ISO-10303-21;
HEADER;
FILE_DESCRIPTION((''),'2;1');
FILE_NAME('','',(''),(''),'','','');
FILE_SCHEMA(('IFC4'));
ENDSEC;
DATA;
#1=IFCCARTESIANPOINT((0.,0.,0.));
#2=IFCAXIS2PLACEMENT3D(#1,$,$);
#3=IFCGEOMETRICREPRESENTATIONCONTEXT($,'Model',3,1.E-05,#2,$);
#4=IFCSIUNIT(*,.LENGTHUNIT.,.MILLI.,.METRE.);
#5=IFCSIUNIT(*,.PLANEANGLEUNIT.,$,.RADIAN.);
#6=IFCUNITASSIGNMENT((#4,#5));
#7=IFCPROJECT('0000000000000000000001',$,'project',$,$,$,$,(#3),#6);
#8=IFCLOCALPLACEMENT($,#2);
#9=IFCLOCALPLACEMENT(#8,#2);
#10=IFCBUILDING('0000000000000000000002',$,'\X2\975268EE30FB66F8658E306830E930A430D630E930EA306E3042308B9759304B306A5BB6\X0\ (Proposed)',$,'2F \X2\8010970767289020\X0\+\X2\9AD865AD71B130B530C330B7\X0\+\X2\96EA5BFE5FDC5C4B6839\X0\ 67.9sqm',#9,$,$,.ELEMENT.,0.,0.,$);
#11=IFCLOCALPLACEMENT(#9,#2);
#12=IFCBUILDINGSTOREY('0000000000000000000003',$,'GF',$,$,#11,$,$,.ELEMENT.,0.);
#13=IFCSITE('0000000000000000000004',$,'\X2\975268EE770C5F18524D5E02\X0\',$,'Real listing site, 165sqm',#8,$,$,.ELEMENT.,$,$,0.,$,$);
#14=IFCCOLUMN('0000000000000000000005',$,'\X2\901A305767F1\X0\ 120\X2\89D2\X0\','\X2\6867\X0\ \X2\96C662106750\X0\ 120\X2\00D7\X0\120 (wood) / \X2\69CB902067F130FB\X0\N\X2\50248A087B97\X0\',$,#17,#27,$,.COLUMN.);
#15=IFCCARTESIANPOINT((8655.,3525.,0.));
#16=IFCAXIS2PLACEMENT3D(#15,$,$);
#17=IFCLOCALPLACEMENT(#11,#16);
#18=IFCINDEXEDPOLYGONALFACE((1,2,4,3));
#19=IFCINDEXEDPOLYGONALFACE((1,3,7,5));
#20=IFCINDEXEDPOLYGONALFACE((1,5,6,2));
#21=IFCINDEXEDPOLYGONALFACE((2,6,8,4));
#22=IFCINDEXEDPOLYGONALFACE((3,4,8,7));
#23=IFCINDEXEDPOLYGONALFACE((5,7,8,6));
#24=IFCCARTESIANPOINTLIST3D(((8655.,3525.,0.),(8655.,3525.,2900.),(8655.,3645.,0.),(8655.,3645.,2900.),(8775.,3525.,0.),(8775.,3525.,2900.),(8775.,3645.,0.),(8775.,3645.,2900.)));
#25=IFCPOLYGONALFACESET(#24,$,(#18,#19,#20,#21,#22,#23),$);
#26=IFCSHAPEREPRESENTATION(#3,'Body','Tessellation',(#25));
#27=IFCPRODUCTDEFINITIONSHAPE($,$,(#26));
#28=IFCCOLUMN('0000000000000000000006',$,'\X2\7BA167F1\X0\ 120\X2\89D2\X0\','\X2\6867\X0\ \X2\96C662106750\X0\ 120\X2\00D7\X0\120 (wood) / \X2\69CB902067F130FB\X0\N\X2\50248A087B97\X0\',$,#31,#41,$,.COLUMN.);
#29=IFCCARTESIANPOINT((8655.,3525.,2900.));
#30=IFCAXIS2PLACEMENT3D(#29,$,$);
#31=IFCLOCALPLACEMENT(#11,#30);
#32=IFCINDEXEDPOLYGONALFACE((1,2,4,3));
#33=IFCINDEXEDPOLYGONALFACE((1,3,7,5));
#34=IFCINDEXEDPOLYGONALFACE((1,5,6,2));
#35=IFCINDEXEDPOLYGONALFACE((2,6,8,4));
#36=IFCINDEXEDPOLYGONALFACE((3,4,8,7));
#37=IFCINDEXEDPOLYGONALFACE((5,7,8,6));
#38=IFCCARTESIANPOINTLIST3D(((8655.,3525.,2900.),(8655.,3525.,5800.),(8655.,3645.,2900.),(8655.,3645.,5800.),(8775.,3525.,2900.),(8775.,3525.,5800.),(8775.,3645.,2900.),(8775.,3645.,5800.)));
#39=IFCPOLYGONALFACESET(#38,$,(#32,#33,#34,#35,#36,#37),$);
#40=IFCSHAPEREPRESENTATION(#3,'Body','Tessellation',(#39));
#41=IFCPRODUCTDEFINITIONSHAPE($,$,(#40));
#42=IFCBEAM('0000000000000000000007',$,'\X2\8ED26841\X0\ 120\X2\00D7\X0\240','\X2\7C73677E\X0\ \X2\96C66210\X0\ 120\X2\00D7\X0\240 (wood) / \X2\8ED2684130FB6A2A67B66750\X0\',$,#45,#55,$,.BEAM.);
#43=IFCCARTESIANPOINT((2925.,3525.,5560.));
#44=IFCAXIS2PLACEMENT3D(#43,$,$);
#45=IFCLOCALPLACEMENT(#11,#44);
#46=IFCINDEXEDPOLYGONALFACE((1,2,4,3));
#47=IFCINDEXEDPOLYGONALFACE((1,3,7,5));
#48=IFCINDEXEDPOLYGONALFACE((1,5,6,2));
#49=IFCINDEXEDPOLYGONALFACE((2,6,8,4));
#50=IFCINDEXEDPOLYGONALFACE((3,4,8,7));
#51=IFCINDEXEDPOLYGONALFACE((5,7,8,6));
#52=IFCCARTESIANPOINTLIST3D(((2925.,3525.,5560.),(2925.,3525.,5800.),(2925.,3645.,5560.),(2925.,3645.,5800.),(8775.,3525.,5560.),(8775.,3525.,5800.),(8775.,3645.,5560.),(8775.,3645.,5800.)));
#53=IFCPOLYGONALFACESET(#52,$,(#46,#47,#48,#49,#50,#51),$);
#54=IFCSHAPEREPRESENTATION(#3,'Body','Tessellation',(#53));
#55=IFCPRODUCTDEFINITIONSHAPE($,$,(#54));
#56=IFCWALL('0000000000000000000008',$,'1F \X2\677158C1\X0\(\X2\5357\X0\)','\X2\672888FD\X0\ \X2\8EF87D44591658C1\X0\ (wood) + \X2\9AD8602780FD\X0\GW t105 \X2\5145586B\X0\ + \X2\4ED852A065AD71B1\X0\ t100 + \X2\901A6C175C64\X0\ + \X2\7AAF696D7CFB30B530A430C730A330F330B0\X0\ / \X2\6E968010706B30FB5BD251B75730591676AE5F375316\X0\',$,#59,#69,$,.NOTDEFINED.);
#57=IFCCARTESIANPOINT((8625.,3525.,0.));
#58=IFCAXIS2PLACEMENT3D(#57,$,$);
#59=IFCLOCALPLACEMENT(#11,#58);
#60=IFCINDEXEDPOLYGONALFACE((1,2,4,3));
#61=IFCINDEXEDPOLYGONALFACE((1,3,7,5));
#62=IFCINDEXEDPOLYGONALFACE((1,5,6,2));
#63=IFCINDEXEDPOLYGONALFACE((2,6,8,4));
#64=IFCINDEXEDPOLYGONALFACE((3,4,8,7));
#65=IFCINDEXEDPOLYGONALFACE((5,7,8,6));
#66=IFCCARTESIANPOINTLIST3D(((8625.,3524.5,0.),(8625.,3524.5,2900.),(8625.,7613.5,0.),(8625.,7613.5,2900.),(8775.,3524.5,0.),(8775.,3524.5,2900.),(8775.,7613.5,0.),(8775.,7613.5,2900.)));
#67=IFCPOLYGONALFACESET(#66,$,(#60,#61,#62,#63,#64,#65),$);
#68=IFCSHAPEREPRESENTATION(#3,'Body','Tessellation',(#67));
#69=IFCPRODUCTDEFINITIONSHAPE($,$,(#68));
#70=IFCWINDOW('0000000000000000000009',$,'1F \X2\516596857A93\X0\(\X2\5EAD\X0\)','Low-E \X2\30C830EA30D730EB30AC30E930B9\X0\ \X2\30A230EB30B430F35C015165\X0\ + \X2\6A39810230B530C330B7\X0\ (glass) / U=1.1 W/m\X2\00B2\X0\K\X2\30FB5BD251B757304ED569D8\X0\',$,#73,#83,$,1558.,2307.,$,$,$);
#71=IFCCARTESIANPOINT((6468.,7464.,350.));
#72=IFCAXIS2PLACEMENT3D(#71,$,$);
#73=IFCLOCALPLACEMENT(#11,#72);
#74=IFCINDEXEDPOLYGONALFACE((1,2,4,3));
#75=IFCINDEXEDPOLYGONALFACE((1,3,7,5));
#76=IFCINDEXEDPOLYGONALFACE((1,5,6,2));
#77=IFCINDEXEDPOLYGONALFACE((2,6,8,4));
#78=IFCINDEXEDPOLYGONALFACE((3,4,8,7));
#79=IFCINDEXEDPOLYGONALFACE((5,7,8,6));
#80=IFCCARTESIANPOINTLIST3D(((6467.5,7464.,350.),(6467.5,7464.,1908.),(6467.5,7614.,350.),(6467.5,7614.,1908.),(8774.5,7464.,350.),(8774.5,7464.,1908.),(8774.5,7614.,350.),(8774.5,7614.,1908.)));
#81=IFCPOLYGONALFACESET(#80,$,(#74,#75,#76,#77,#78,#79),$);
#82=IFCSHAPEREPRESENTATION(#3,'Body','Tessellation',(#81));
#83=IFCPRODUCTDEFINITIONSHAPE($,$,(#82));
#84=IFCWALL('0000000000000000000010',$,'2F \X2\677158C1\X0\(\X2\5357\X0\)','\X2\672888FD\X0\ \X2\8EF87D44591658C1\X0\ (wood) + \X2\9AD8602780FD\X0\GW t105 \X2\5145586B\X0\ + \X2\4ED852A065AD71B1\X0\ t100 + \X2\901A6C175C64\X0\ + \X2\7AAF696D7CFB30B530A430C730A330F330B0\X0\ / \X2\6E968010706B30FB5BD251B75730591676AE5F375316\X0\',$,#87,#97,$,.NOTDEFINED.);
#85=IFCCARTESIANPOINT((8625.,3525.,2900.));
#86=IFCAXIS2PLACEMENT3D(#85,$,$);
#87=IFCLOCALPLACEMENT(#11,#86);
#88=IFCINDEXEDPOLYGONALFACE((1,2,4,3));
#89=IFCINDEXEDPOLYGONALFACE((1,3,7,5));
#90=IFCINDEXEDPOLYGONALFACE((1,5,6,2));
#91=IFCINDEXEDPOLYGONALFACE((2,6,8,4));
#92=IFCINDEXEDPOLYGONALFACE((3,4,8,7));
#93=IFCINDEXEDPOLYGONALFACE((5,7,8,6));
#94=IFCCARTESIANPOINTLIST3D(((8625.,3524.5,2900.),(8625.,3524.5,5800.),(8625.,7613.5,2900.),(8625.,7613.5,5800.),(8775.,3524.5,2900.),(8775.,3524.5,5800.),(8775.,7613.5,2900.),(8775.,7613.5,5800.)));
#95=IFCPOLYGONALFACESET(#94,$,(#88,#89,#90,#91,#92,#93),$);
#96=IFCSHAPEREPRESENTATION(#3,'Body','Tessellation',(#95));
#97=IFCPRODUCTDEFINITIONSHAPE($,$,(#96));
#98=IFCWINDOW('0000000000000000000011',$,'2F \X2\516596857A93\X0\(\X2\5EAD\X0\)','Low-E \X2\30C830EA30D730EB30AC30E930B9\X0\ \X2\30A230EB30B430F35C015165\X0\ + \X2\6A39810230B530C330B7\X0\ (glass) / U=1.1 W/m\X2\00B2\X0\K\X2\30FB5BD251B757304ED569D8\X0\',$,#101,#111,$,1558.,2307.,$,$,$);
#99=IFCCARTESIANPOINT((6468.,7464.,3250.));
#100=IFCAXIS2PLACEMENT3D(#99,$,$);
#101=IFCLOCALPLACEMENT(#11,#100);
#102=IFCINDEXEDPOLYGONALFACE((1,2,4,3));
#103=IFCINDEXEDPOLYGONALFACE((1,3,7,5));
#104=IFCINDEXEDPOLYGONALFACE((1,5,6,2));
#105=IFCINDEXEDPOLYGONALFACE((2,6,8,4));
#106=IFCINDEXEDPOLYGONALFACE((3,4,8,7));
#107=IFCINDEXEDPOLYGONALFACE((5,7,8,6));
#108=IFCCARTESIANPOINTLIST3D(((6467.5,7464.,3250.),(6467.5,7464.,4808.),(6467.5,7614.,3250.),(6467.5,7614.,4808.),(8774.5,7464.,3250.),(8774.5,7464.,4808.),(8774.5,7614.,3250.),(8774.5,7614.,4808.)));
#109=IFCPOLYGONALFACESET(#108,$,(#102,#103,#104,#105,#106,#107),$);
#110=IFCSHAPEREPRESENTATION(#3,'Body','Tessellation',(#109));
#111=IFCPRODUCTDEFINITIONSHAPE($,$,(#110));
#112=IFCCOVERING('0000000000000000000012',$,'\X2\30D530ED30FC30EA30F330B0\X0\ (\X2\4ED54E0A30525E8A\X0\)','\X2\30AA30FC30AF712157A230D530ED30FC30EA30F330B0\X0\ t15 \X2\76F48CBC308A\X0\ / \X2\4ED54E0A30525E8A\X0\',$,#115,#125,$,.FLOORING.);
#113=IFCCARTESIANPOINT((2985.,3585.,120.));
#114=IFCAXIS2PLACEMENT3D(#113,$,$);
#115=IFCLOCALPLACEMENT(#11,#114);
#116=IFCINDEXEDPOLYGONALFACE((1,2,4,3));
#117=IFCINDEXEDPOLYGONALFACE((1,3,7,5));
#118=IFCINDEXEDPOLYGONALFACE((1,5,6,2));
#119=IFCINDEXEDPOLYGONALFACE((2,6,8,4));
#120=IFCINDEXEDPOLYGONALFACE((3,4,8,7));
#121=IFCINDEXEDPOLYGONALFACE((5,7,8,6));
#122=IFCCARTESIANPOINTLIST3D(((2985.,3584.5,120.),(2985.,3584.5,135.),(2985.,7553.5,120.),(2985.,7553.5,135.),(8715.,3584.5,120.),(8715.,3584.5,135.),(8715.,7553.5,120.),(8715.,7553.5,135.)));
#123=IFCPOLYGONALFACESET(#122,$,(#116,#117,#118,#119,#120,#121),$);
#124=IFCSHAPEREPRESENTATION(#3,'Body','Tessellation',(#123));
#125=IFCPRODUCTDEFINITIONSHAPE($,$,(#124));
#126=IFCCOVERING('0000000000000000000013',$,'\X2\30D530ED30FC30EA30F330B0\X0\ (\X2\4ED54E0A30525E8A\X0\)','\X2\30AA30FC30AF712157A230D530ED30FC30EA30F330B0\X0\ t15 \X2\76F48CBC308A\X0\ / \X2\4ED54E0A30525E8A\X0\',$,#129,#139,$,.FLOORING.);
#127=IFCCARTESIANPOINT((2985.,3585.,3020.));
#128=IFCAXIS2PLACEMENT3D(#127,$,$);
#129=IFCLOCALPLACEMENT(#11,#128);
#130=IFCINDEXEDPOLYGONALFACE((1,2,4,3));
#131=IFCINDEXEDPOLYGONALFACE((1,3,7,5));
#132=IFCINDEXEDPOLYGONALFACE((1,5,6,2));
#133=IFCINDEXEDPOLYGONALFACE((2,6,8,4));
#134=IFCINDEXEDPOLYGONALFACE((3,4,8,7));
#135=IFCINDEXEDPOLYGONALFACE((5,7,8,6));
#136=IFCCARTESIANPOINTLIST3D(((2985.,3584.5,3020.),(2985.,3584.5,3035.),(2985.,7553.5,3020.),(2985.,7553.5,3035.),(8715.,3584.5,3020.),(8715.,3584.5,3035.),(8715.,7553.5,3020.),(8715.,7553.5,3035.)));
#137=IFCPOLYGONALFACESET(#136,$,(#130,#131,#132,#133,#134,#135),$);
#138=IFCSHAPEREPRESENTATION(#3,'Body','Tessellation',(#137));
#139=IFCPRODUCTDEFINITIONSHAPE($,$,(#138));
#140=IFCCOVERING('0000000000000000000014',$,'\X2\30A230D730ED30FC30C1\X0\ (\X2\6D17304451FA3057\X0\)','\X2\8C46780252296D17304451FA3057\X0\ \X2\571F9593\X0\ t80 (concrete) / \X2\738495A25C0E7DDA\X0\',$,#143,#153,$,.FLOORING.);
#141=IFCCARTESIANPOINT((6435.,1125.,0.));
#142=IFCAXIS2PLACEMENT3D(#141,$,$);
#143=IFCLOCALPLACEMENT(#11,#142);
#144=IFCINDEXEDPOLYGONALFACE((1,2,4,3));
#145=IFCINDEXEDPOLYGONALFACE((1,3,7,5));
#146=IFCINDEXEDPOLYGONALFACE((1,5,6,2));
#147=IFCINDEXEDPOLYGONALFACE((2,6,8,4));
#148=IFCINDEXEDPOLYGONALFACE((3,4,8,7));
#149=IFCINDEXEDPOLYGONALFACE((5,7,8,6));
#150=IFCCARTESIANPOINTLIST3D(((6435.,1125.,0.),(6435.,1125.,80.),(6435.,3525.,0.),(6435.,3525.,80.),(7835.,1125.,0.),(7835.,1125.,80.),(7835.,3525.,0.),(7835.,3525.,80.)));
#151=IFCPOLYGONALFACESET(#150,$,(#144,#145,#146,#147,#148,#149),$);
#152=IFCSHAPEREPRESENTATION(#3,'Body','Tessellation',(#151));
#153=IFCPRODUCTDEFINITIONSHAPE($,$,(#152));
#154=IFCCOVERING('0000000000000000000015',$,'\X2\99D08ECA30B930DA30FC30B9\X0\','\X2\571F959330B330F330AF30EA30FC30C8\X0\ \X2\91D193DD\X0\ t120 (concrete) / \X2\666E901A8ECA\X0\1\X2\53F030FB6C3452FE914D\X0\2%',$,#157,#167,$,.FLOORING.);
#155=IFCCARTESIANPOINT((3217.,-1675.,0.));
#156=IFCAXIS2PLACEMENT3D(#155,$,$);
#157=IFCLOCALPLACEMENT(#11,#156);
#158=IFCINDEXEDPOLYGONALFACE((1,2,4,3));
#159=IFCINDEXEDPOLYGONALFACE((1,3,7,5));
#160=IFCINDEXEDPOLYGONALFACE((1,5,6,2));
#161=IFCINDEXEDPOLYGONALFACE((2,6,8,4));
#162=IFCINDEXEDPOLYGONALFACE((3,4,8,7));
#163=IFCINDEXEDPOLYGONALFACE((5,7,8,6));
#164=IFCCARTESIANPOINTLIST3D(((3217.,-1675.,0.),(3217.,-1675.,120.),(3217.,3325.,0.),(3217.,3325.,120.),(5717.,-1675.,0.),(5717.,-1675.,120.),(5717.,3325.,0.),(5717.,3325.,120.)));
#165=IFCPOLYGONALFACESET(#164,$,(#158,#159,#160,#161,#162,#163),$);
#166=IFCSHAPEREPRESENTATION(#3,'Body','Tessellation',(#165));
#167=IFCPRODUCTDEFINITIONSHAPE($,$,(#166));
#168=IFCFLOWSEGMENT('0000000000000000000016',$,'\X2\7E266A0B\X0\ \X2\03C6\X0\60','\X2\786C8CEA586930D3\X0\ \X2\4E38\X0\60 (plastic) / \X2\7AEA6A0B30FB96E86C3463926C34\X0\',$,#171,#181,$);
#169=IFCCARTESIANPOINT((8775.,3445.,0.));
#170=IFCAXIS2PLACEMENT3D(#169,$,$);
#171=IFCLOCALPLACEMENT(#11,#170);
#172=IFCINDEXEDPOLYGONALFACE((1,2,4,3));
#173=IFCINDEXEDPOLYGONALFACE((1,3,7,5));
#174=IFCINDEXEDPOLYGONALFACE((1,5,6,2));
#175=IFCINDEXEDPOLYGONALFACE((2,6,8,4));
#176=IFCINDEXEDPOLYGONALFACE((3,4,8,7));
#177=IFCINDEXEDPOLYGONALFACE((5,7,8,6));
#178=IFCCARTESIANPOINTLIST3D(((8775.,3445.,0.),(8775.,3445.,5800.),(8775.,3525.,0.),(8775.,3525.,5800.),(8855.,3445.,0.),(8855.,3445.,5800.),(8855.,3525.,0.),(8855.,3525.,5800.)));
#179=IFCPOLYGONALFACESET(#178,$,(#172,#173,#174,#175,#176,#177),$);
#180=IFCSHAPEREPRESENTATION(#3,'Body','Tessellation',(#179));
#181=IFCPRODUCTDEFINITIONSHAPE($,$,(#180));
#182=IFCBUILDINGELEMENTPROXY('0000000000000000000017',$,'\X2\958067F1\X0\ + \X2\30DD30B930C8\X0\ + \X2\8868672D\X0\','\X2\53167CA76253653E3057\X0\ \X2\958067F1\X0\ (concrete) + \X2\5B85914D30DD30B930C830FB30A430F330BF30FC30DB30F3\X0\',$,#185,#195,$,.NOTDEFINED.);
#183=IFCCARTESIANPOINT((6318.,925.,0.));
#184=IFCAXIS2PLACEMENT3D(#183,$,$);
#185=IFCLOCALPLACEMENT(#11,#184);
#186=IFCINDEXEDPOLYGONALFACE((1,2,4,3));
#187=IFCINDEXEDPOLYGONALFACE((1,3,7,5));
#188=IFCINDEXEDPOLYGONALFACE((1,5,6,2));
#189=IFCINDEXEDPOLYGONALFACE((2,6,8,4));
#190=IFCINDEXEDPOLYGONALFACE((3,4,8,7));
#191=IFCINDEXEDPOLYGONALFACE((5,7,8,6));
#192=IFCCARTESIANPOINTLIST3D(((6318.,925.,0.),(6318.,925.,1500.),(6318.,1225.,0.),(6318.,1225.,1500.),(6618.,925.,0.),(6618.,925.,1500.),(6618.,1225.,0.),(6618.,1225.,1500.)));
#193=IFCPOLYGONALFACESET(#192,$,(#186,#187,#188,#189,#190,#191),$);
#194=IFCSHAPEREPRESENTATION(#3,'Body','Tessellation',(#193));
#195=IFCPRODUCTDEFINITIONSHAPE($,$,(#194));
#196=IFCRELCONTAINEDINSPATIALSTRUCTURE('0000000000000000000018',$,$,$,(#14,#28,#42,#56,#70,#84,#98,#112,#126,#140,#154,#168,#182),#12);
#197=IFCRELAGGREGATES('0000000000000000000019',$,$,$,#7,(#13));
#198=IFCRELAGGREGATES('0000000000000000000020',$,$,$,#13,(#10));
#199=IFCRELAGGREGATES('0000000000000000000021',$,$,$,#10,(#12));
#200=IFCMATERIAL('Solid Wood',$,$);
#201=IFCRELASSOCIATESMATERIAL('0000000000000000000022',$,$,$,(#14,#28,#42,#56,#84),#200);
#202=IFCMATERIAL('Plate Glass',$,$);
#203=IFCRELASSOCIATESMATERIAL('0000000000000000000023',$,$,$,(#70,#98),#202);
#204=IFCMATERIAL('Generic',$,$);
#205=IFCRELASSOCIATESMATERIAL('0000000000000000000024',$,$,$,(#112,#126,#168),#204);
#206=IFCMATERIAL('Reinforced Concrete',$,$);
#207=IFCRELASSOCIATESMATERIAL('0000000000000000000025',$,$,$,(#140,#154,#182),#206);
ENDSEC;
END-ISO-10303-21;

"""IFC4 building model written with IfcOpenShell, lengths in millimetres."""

from ifc_helpers import new_model, si_unit, frame, frame_2d, origin, place, context, project, spatial, rectangle, extrude, material, element, fill, save


model = new_model("IFC4")

# Units and contexts
model_context = context("Model", 3, precision=1e-05, world=origin())
ifc_project = project(units=[si_unit("LENGTHUNIT", "METRE", prefix="MILLI"), si_unit("PLANEANGLEUNIT", "RADIAN")], contexts=[model_context])

# Site, building, storey
site_placement = place(None, origin())
site = spatial("IfcSite", under=ifc_project, at=site_placement, Name="青森県弘前市", ObjectType="Real listing site, 165sqm", CompositionType="ELEMENT", RefElevation=0.0)
building_placement = place(site_placement, origin())
building = spatial("IfcBuilding", under=site, at=building_placement, Name="青森・書斎とライブラリのある静かな家 (Proposed)", ObjectType="2F 耐震木造+高断熱サッシ+雪対応屋根 67.9sqm", CompositionType="ELEMENT", ElevationOfRefHeight=0.0, ElevationOfTerrain=0.0)
storey_placement = place(building_placement, origin())
storey = spatial("IfcBuildingStorey", under=building, at=storey_placement, Name="GF", CompositionType="ELEMENT", Elevation=0.0)

# Columns
ifc_material_1 = material(Name="Solid Wood")
column_1_placement = place(storey_placement, frame((8655.0, 3525.0, 0.0)))
element("IfcColumn", 1, at=column_1_placement, inside=storey, material=ifc_material_1, Name="通し柱 120角", Description="桧 集成材 120×120 (wood) / 構造柱・N値計算", PredefinedType="COLUMN", context=model_context, shape_type="SweptSolid", body=[
    extrude(rectangle(XDim=120.0, YDim=120.0, at=frame_2d((60.0, 60.0))), frame((8655.0, 3525.0, 0.0)), (0.0, 0.0, 1.0), 2900.0),
])
column_2_placement = place(storey_placement, frame((8655.0, 3525.0, 2900.0)))
element("IfcColumn", 2, at=column_2_placement, inside=storey, material=ifc_material_1, Name="管柱 120角", Description="桧 集成材 120×120 (wood) / 構造柱・N値計算", PredefinedType="COLUMN", context=model_context, shape_type="SweptSolid", body=[
    extrude(rectangle(XDim=120.0, YDim=120.0, at=frame_2d((60.0, 60.0))), frame((8655.0, 3525.0, 2900.0)), (0.0, 0.0, 1.0), 2900.0),
])

# Beam
beam_1_placement = place(storey_placement, frame((2925.0, 3525.0, 5560.0)))
element("IfcBeam", 3, at=beam_1_placement, inside=storey, material=ifc_material_1, Name="軒桁 120×240", Description="米松 集成 120×240 (wood) / 軒桁・横架材", PredefinedType="BEAM", context=model_context, shape_type="SweptSolid", body=[
    extrude(rectangle(XDim=5850.0, YDim=120.0, at=frame_2d((2925.0, 60.0))), frame((2925.0, 3525.0, 5560.0)), (0.0, 0.0, 1.0), 240.0),
])

# Wall, opening, window
wall_1_placement = place(storey_placement, frame((8625.0, 3525.0, 0.0)))
wall_1 = element("IfcWall", 4, at=wall_1_placement, inside=storey, material=ifc_material_1, Name="1F 東壁(南)", Description="木製 軸組外壁 (wood) + 高性能GW t105 充填 + 付加断熱 t100 + 通気層 + 窯業系サイディング / 準耐火・寒冷地外皮強化", PredefinedType="NOTDEFINED", context=model_context, shape_type="SweptSolid", body=[
    extrude(rectangle(XDim=150.0, YDim=4089.0, at=frame_2d((75.0, 2044.0))), frame((8625.0, 3525.0, 0.0)), (0.0, 0.0, 1.0), 2900.0),
])
opening_1_placement = place(storey_placement, frame((6468.0, 7464.0, 350.0)))
opening_1 = element("IfcOpeningElement", 5, at=opening_1_placement, cuts=wall_1, PredefinedType="NOTDEFINED", context=model_context, shape_type="SweptSolid", body=[
    extrude(rectangle(XDim=2307.0, YDim=150.0, at=frame_2d((1153.0, 75.0))), frame((6468.0, 7464.0, 350.0)), (0.0, 0.0, 1.0), 1558.0),
])
ifc_material_2 = material(Name="Plate Glass")
window_1_placement = place(storey_placement, frame((6468.0, 7464.0, 350.0)))
window_1 = element("IfcWindow", 6, at=window_1_placement, inside=storey, material=ifc_material_2, Name="1F 入隅窓(庭)", Description="Low-E トリプルガラス アルゴン封入 + 樹脂サッシ (glass) / U=1.1 W/m²K・寒冷地仕様", OverallHeight=1558.0, OverallWidth=2307.0, context=model_context, shape_type="SweptSolid", body=[
    extrude(rectangle(XDim=2307.0, YDim=150.0, at=frame_2d((1153.0, 75.0))), frame((6468.0, 7464.0, 350.0)), (0.0, 0.0, 1.0), 1558.0),
])
fill(opening_1, window_1)

# Wall, opening, window
wall_2_placement = place(storey_placement, frame((8625.0, 3525.0, 2900.0)))
wall_2 = element("IfcWall", 7, at=wall_2_placement, inside=storey, material=ifc_material_1, Name="2F 東壁(南)", Description="木製 軸組外壁 (wood) + 高性能GW t105 充填 + 付加断熱 t100 + 通気層 + 窯業系サイディング / 準耐火・寒冷地外皮強化", PredefinedType="NOTDEFINED", context=model_context, shape_type="SweptSolid", body=[
    extrude(rectangle(XDim=150.0, YDim=4089.0, at=frame_2d((75.0, 2044.0))), frame((8625.0, 3525.0, 2900.0)), (0.0, 0.0, 1.0), 2900.0),
])
opening_2_placement = place(storey_placement, frame((6468.0, 7464.0, 3250.0)))
opening_2 = element("IfcOpeningElement", 8, at=opening_2_placement, cuts=wall_2, PredefinedType="NOTDEFINED", context=model_context, shape_type="SweptSolid", body=[
    extrude(rectangle(XDim=2307.0, YDim=150.0, at=frame_2d((1153.0, 75.0))), frame((6468.0, 7464.0, 3250.0)), (0.0, 0.0, 1.0), 1558.0),
])
window_2_placement = place(storey_placement, frame((6468.0, 7464.0, 3250.0)))
window_2 = element("IfcWindow", 9, at=window_2_placement, inside=storey, material=ifc_material_2, Name="2F 入隅窓(庭)", Description="Low-E トリプルガラス アルゴン封入 + 樹脂サッシ (glass) / U=1.1 W/m²K・寒冷地仕様", OverallHeight=1558.0, OverallWidth=2307.0, context=model_context, shape_type="SweptSolid", body=[
    extrude(rectangle(XDim=2307.0, YDim=150.0, at=frame_2d((1153.0, 75.0))), frame((6468.0, 7464.0, 3250.0)), (0.0, 0.0, 1.0), 1558.0),
])
fill(opening_2, window_2)

# Coverings
ifc_material_3 = material(Name="Generic")
covering_1_placement = place(storey_placement, frame((2985.0, 3585.0, 120.0)))
element("IfcCovering", 10, at=covering_1_placement, inside=storey, material=ifc_material_3, Name="フローリング (仕上げ床)", Description="オーク無垢フローリング t15 直貼り / 仕上げ床", PredefinedType="FLOORING", context=model_context, shape_type="SweptSolid", body=[
    extrude(rectangle(XDim=5730.0, YDim=3969.0, at=frame_2d((2865.0, 1984.0))), frame((2985.0, 3585.0, 120.0)), (0.0, 0.0, 1.0), 15.0),
])
covering_2_placement = place(storey_placement, frame((2985.0, 3585.0, 3020.0)))
element("IfcCovering", 11, at=covering_2_placement, inside=storey, material=ifc_material_3, Name="フローリング (仕上げ床)", Description="オーク無垢フローリング t15 直貼り / 仕上げ床", PredefinedType="FLOORING", context=model_context, shape_type="SweptSolid", body=[
    extrude(rectangle(XDim=5730.0, YDim=3969.0, at=frame_2d((2865.0, 1984.0))), frame((2985.0, 3585.0, 3020.0)), (0.0, 0.0, 1.0), 15.0),
])
ifc_material_4 = material(Name="Reinforced Concrete")
covering_3_placement = place(storey_placement, frame((6435.0, 1125.0, 0.0)))
element("IfcCovering", 12, at=covering_3_placement, inside=storey, material=ifc_material_4, Name="アプローチ (洗い出し)", Description="豆砂利洗い出し 土間 t80 (concrete) / 玄関導線", PredefinedType="FLOORING", context=model_context, shape_type="SweptSolid", body=[
    extrude(rectangle(XDim=1400.0, YDim=2400.0, at=frame_2d((700.0, 1200.0))), frame((6435.0, 1125.0, 0.0)), (0.0, 0.0, 1.0), 80.0),
])
covering_4_placement = place(storey_placement, frame((3217.0, -1675.0, 0.0)))
element("IfcCovering", 13, at=covering_4_placement, inside=storey, material=ifc_material_4, Name="駐車スペース", Description="土間コンクリート 金鏝 t120 (concrete) / 普通車1台・水勾配2%", PredefinedType="FLOORING", context=model_context, shape_type="SweptSolid", body=[
    extrude(rectangle(XDim=2500.0, YDim=5000.0, at=frame_2d((1250.0, 2500.0))), frame((3217.0, -1675.0, 0.0)), (0.0, 0.0, 1.0), 120.0),
])

# Flow segment
flow_segment_placement = place(storey_placement, frame((8775.0, 3445.0, 0.0)))
element("IfcFlowSegment", 14, at=flow_segment_placement, inside=storey, material=ifc_material_3, Name="縦樋 φ60", Description="硬質塩ビ 丸60 (plastic) / 竪樋・雨水排水", context=model_context, shape_type="SweptSolid", body=[
    extrude(rectangle(XDim=80.0, YDim=80.0, at=frame_2d((40.0, 40.0))), frame((8775.0, 3445.0, 0.0)), (0.0, 0.0, 1.0), 5800.0),
])

# Building element proxy
proxy_placement = place(storey_placement, frame((6318.0, 925.0, 0.0)))
element("IfcBuildingElementProxy", 15, at=proxy_placement, inside=storey, material=ifc_material_4, Name="門柱 + ポスト + 表札", Description="化粧打放し 門柱 (concrete) + 宅配ポスト・インターホン", PredefinedType="NOTDEFINED", context=model_context, shape_type="SweptSolid", body=[
    extrude(rectangle(XDim=300.0, YDim=300.0, at=frame_2d((150.0, 150.0))), frame((6318.0, 925.0, 0.0)), (0.0, 0.0, 1.0), 1500.0),
])

save(model, "model.ifc")
